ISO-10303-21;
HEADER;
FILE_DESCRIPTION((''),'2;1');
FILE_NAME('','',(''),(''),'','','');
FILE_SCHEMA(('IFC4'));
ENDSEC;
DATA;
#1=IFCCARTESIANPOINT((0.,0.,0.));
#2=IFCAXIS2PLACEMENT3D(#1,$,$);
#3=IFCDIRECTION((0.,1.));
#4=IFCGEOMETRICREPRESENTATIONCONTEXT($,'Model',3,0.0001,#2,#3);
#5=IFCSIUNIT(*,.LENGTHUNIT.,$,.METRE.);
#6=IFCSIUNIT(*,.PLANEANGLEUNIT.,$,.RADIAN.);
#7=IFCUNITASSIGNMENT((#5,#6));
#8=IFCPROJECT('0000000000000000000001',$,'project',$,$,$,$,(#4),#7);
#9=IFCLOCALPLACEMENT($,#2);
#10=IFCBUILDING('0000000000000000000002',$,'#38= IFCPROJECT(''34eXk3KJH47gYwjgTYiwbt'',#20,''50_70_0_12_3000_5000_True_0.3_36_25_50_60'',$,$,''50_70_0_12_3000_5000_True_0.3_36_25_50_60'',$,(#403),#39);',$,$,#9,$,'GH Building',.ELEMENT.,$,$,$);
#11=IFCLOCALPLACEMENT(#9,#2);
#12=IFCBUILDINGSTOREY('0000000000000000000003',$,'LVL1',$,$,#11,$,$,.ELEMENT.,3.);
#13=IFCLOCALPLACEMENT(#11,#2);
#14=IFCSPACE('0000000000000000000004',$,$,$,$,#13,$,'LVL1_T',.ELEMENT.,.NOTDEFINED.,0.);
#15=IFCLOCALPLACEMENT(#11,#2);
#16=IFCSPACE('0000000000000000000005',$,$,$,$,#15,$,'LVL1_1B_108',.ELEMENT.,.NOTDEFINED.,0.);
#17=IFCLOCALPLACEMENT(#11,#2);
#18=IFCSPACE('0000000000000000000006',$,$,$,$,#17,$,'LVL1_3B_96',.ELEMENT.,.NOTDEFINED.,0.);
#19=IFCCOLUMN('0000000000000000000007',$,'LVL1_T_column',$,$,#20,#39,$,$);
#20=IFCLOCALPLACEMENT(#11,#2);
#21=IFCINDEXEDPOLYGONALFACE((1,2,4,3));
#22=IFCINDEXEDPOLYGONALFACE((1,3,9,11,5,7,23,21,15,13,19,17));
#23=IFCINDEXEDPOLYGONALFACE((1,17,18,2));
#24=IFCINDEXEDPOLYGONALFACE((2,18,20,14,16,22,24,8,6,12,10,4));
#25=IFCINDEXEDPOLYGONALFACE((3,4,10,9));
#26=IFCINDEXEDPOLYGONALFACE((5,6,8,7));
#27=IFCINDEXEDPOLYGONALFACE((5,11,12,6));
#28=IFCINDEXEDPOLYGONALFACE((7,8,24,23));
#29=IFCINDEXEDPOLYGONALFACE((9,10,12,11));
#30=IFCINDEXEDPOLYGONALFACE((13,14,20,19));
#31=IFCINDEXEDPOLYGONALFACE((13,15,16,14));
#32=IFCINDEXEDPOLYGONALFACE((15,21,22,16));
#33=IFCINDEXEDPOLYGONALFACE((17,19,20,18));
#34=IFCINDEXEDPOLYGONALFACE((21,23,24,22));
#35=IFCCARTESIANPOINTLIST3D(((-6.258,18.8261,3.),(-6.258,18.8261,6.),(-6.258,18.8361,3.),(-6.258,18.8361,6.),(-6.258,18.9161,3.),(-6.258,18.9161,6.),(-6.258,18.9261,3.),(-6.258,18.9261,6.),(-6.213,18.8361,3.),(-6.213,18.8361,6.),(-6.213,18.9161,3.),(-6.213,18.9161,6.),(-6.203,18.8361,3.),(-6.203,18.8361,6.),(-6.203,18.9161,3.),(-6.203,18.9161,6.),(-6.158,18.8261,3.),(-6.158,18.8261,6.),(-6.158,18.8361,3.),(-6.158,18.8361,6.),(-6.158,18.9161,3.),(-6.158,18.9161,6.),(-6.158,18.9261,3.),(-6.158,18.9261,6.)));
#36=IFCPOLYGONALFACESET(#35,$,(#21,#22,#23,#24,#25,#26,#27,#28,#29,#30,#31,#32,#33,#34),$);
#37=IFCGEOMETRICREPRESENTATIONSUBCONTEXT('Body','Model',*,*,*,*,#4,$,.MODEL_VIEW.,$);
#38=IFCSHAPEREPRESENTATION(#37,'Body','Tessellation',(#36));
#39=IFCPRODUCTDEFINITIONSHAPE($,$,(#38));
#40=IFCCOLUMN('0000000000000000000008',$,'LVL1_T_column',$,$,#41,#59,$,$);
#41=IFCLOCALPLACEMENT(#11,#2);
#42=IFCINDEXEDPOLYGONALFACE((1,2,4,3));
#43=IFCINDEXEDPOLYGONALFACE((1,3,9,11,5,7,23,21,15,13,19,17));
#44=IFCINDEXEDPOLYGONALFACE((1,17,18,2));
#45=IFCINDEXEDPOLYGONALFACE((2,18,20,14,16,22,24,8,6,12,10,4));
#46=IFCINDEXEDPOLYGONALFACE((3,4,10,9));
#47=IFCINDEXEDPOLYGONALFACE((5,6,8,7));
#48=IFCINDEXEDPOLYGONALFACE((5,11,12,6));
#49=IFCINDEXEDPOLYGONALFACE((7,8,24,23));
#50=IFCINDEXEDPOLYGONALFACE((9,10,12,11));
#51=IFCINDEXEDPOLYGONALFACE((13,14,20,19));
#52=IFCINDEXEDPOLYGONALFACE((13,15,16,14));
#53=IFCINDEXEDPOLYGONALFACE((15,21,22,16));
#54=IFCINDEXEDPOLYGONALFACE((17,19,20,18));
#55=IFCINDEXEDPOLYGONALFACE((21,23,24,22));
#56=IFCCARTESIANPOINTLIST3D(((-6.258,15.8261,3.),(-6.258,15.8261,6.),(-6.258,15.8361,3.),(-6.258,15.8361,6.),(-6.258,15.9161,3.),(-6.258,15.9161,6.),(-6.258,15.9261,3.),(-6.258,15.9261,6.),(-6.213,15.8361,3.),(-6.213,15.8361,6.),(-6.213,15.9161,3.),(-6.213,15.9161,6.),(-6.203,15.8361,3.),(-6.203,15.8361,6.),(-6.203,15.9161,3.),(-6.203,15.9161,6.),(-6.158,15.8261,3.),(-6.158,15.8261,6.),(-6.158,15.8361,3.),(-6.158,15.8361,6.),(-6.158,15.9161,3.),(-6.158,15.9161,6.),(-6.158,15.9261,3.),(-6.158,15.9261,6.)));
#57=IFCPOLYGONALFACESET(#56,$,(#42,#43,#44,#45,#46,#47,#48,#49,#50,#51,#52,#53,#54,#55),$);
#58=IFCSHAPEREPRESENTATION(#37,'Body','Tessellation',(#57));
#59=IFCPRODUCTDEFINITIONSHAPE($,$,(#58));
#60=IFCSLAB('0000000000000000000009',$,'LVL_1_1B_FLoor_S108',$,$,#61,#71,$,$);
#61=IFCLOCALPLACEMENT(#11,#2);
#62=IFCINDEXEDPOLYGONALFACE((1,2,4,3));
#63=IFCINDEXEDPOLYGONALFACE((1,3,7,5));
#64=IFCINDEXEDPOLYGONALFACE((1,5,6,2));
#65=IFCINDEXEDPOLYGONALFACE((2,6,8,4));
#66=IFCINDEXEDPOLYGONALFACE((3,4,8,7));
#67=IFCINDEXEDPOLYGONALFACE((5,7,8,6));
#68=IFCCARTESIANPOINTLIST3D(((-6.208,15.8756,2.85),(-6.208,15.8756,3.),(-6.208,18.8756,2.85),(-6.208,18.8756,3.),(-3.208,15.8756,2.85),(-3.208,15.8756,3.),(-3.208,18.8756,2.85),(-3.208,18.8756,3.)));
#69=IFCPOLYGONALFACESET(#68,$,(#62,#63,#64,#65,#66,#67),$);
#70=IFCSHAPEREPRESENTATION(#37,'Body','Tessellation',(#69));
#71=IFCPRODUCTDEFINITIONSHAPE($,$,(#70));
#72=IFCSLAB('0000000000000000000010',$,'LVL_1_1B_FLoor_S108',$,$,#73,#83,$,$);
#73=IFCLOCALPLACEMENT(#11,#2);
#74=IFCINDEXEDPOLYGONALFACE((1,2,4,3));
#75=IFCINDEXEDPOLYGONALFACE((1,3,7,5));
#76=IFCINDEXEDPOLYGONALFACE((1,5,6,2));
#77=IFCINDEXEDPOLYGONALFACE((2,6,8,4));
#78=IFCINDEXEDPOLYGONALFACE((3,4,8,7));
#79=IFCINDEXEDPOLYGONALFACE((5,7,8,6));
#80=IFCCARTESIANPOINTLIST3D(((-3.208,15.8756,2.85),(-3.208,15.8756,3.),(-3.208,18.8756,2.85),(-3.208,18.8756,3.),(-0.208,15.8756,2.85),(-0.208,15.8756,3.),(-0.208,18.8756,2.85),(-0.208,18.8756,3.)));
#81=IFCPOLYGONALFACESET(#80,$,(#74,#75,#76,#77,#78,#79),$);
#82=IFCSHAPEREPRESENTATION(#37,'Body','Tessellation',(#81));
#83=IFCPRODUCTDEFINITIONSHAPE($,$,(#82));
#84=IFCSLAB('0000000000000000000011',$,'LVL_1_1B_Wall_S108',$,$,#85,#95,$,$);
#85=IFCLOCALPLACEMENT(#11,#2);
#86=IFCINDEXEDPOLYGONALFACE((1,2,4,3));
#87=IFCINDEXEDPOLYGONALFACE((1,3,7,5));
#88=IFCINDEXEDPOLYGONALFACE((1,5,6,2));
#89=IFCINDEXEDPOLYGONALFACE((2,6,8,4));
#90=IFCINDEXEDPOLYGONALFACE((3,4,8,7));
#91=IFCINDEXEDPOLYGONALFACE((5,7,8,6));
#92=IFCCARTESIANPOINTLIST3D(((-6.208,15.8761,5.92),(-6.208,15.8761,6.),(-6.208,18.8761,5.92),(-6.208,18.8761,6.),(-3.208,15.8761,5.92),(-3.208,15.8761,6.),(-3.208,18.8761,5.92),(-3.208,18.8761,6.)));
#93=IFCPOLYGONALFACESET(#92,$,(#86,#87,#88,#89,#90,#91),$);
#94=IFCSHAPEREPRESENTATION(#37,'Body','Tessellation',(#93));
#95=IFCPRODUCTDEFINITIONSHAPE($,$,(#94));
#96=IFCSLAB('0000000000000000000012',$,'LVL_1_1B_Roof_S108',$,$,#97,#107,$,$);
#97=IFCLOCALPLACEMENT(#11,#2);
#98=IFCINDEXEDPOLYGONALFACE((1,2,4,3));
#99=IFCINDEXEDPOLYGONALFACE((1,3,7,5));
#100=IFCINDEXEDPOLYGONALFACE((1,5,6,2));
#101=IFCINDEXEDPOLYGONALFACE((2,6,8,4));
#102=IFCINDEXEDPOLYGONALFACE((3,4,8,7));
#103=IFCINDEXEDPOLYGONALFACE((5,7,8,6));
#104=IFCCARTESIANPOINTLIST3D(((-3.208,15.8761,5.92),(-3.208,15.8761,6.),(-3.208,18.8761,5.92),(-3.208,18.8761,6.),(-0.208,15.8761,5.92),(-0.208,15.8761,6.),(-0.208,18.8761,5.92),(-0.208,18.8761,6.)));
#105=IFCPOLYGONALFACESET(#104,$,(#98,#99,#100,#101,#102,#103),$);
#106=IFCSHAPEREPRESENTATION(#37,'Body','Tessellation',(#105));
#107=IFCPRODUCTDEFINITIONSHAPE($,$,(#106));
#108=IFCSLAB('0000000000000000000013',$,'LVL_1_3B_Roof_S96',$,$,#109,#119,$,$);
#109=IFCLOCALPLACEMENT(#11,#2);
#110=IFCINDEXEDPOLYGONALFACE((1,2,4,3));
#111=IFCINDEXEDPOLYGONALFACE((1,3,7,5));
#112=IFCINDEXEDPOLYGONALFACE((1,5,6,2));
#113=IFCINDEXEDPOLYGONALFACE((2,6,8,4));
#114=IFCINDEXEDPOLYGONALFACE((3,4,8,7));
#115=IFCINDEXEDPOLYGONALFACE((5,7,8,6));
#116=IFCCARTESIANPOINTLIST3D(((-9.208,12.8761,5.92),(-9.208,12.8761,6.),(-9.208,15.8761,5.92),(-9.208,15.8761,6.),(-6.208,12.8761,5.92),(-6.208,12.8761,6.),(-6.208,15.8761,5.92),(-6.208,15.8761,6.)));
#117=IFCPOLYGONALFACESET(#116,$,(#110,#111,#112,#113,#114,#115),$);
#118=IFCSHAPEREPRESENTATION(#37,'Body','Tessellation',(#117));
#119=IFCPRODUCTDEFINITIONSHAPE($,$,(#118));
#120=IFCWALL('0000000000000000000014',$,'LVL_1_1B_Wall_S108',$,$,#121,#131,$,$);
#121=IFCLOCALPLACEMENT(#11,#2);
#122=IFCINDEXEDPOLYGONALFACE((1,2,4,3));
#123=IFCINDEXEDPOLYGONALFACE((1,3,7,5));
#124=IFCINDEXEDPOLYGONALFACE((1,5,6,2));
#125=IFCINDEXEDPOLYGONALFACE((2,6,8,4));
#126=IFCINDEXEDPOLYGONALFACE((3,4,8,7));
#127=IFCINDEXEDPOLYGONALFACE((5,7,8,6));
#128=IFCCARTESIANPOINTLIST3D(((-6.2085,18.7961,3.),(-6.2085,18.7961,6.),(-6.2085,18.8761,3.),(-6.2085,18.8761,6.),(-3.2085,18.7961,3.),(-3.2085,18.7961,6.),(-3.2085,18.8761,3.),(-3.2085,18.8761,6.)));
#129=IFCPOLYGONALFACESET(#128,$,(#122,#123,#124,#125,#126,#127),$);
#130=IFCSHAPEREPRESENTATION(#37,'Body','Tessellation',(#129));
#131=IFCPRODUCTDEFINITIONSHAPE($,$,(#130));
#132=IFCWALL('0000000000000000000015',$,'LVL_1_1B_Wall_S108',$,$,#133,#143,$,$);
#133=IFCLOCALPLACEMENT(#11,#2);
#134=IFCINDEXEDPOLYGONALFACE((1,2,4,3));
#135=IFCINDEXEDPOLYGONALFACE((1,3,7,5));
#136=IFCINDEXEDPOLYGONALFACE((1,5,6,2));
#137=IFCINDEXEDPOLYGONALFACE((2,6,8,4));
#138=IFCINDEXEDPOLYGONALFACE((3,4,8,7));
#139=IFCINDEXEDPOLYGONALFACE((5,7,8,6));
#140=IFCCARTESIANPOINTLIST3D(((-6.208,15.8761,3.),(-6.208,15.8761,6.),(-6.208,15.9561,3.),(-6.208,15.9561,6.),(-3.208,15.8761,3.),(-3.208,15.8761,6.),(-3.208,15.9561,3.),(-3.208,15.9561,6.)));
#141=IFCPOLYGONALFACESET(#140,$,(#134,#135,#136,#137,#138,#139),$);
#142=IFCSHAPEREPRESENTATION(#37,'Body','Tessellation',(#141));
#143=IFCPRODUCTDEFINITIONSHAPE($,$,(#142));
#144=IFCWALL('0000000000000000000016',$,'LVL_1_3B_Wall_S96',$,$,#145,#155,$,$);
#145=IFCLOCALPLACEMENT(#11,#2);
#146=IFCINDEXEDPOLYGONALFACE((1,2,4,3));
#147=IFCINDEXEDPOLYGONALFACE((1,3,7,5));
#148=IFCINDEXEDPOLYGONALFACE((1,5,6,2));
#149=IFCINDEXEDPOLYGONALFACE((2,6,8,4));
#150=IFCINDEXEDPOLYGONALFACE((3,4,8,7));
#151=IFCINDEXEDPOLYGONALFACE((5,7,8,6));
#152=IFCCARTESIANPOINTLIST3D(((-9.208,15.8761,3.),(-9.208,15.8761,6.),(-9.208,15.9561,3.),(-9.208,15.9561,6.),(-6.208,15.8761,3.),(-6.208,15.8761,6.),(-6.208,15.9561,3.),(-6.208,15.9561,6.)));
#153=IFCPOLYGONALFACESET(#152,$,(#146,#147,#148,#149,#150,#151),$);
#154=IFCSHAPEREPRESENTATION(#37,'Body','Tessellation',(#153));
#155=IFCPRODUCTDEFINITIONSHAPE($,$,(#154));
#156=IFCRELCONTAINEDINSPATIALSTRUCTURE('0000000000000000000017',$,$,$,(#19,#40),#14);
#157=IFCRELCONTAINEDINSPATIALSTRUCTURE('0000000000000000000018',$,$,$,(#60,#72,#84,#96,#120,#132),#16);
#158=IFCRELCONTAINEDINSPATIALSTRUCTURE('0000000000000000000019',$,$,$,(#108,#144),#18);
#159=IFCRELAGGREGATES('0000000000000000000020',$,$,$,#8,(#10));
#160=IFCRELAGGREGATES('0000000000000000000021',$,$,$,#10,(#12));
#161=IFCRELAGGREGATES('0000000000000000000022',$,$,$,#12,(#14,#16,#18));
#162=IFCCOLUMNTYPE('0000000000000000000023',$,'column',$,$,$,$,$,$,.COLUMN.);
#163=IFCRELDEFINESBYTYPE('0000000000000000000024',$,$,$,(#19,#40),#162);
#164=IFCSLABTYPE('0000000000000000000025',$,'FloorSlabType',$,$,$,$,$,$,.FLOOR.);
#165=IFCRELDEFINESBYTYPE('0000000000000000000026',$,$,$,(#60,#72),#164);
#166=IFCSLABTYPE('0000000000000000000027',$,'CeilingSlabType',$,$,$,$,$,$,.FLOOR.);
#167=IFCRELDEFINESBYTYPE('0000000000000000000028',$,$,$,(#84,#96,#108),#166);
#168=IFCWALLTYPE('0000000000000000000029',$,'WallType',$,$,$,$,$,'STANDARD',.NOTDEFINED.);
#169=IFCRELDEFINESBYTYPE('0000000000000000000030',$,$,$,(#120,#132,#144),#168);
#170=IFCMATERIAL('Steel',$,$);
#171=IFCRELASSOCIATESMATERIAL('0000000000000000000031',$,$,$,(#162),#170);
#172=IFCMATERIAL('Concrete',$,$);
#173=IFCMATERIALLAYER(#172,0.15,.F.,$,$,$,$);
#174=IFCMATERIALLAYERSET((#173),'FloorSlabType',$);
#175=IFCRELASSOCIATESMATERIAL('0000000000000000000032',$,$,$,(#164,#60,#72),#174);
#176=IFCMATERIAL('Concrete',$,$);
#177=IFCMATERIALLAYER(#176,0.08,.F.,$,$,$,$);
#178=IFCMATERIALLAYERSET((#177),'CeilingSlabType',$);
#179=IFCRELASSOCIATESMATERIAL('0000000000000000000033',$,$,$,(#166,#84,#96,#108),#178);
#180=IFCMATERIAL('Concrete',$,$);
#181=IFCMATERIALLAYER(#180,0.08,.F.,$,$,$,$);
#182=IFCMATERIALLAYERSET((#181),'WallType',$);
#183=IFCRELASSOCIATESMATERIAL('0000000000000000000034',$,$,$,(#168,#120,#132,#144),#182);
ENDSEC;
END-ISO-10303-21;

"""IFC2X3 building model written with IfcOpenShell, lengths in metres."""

from ifc_helpers import new_model, si_unit, direction, frame, frame_2d, origin, origin_2d, place, context, subcontext, project, spatial, rectangle, i_section, extrude, material, layer, layer_set, layer_usage, type_object, element, save


model = new_model("IFC2X3")

# Units and contexts
model_context = context("Model", 3, precision=0.0001, world=origin(), true_north=direction((0.0, 1.0)))
body_context = subcontext(model_context, "Body", "Model", "MODEL_VIEW")
ifc_project = project(units=[si_unit("LENGTHUNIT", "METRE"), si_unit("PLANEANGLEUNIT", "RADIAN")], contexts=[model_context])

# Building, storey, space
building_placement = place(None, origin())
building = spatial("IfcBuilding", under=ifc_project, at=building_placement, Name="#38= IFCPROJECT('34eXk3KJH47gYwjgTYiwbt',#20,'50_70_0_12_3000_5000_True_0.3_36_25_50_60',$,$,'50_70_0_12_3000_5000_True_0.3_36_25_50_60',$,(#403),#39);", LongName="GH Building", CompositionType="ELEMENT")
storey_placement = place(building_placement, origin())
storey = spatial("IfcBuildingStorey", under=building, at=storey_placement, Name="LVL1", CompositionType="ELEMENT", Elevation=3.0)
space_1_placement = place(storey_placement, origin())
space_1 = spatial("IfcSpace", under=storey, at=space_1_placement, LongName="LVL1_T", CompositionType="ELEMENT", InteriorOrExteriorSpace="NOTDEFINED", ElevationWithFlooring=0.0)

# Columns
ifc_material_1 = material(Name="Steel")
column_type = type_object("IfcColumnType", Name="column", PredefinedType="COLUMN", material=ifc_material_1)
for number, where, name in (
    (1, (-6.208, 18.8761, 3.0), "LVL1_T_column"),
    (2, (-6.208, 15.8761, 3.0), "LVL1_T_column"),
):
    element("IfcColumn", number, at=place(space_1_placement, frame(where)), inside=space_1, type_object=column_type, Name=name, context=body_context, shape_type="SweptSolid", body=[
        extrude(i_section(OverallWidth=0.1, OverallDepth=0.1, WebThickness=0.01, FlangeThickness=0.01, at=origin_2d()), origin(), (0.0, 0.0, 1.0), 3.0),
    ])

# Shared definitions
space_2_placement = place(storey_placement, origin())
space_2 = spatial("IfcSpace", under=storey, at=space_2_placement, LongName="LVL1_1B_108", CompositionType="ELEMENT", InteriorOrExteriorSpace="NOTDEFINED", ElevationWithFlooring=0.0)

# Slabs
ifc_material_2 = material(Name="Concrete")
ifc_layer_1 = layer(ifc_material_2, 0.15, ventilated=False)
ifc_layer_set_1 = layer_set([ifc_layer_1], Name="FloorSlabType")
ifc_layer_usage_1 = layer_usage(ifc_layer_set_1, "AXIS3", "NEGATIVE", -0.15)
slab_type_1 = type_object("IfcSlabType", Name="FloorSlabType", PredefinedType="FLOOR", material=ifc_layer_set_1)
slab_1_placement = place(space_2_placement, frame((-6.208, 15.8756, 2.85)))
element("IfcSlab", 3, at=slab_1_placement, inside=space_2, type_object=slab_type_1, material=ifc_layer_usage_1, Name="LVL_1_1B_FLoor_S108", context=body_context, shape_type="SweptSolid", body=[
    extrude(rectangle(XDim=3.0, YDim=3.0, at=frame_2d((1.5, 1.5))), origin(), (0.0, 0.0, 1.0), 0.15),
])
ifc_layer_usage_2 = layer_usage(ifc_layer_set_1, "AXIS3", "NEGATIVE", -0.15)
slab_2_placement = place(space_2_placement, frame((-3.208, 15.8756, 2.85)))
element("IfcSlab", 4, at=slab_2_placement, inside=space_2, type_object=slab_type_1, material=ifc_layer_usage_2, Name="LVL_1_1B_FLoor_S108", context=body_context, shape_type="SweptSolid", body=[
    extrude(rectangle(XDim=3.0, YDim=3.0, at=frame_2d((1.5, 1.5))), origin(), (0.0, 0.0, 1.0), 0.15),
])
ifc_material_3 = material(Name="Concrete")
ifc_layer_2 = layer(ifc_material_3, 0.08, ventilated=False)
ifc_layer_set_2 = layer_set([ifc_layer_2], Name="CeilingSlabType")
ifc_layer_usage_3 = layer_usage(ifc_layer_set_2, "AXIS3", "NEGATIVE", -0.08)
slab_type_2 = type_object("IfcSlabType", Name="CeilingSlabType", PredefinedType="FLOOR", material=ifc_layer_set_2)
slab_3_placement = place(space_2_placement, frame((-6.208, 15.8761, 5.92)))
element("IfcSlab", 5, at=slab_3_placement, inside=space_2, type_object=slab_type_2, material=ifc_layer_usage_3, Name="LVL_1_1B_Wall_S108", context=body_context, shape_type="SweptSolid", body=[
    extrude(rectangle(XDim=3.0, YDim=3.0, at=frame_2d((1.5, 1.5))), origin(), (0.0, 0.0, 1.0), 0.08),
])
ifc_layer_usage_4 = layer_usage(ifc_layer_set_2, "AXIS3", "NEGATIVE", -0.08)
slab_4_placement = place(space_2_placement, frame((-3.208, 15.8761, 5.92)))
element("IfcSlab", 6, at=slab_4_placement, inside=space_2, type_object=slab_type_2, material=ifc_layer_usage_4, Name="LVL_1_1B_Roof_S108", context=body_context, shape_type="SweptSolid", body=[
    extrude(rectangle(XDim=3.0, YDim=3.0, at=frame_2d((1.5, 1.5))), origin(), (0.0, 0.0, 1.0), 0.08),
])

# Shared definitions
space_3_placement = place(storey_placement, origin())
space_3 = spatial("IfcSpace", under=storey, at=space_3_placement, LongName="LVL1_3B_96", CompositionType="ELEMENT", InteriorOrExteriorSpace="NOTDEFINED", ElevationWithFlooring=0.0)

# Slab
ifc_layer_usage_5 = layer_usage(ifc_layer_set_2, "AXIS3", "NEGATIVE", -0.08)
slab_5_placement = place(space_3_placement, frame((-6.208, 12.8761, 5.92), z_axis=(0.0, 0.0, 1.0), x_axis=(-1.0, 0.0, 0.0)))
element("IfcSlab", 7, at=slab_5_placement, inside=space_3, type_object=slab_type_2, material=ifc_layer_usage_5, Name="LVL_1_3B_Roof_S96", context=body_context, shape_type="SweptSolid", body=[
    extrude(rectangle(XDim=3.0, YDim=3.0, at=frame_2d((1.5, -1.5))), origin(), (0.0, 0.0, 1.0), 0.08),
])

# Shared definitions
ifc_material_4 = material(Name="Concrete")
ifc_layer_3 = layer(ifc_material_4, 0.08, ventilated=False)
ifc_layer_set_3 = layer_set([ifc_layer_3], Name="WallType")
wall_type = type_object("IfcWallType", Name="WallType", ElementType="STANDARD", PredefinedType="NOTDEFINED", material=ifc_layer_set_3)

# Walls
ifc_layer_usage_6 = layer_usage(ifc_layer_set_3, "AXIS2", "NEGATIVE", 0.0)
wall_1_placement = place(space_2_placement, frame((-6.2085, 18.8761, 3.0)))
element("IfcWall", 8, at=wall_1_placement, inside=space_2, type_object=wall_type, material=ifc_layer_usage_6, Name="LVL_1_1B_Wall_S108", context=body_context, shape_type="SweptSolid", body=[
    extrude(rectangle(XDim=3.0, YDim=0.08, at=frame_2d((1.5, -0.04))), origin(), (0.0, 0.0, 1.0), 3.0),
])
ifc_layer_usage_7 = layer_usage(ifc_layer_set_3, "AXIS2", "NEGATIVE", 0.0)
wall_2_placement = place(space_2_placement, frame((-3.208, 15.8761, 3.0), z_axis=(0.0, 0.0, 1.0), x_axis=(-1.0, 0.0, 0.0)))
element("IfcWall", 9, at=wall_2_placement, inside=space_2, type_object=wall_type, material=ifc_layer_usage_7, Name="LVL_1_1B_Wall_S108", context=body_context, shape_type="SweptSolid", body=[
    extrude(rectangle(XDim=3.0, YDim=0.08, at=frame_2d((1.5, -0.04))), origin(), (0.0, 0.0, 1.0), 3.0),
])

# Wall
ifc_layer_usage_8 = layer_usage(ifc_layer_set_3, "AXIS2", "NEGATIVE", 0.0)
wall_3_placement = place(space_3_placement, frame((-6.208, 15.8761, 3.0), z_axis=(0.0, 0.0, 1.0), x_axis=(-1.0, 0.0, 0.0)))
element("IfcWall", 10, at=wall_3_placement, inside=space_3, type_object=wall_type, material=ifc_layer_usage_8, Name="LVL_1_3B_Wall_S96", context=body_context, shape_type="SweptSolid", body=[
    extrude(rectangle(XDim=3.0, YDim=0.08, at=frame_2d((1.5, -0.04))), origin(), (0.0, 0.0, 1.0), 3.0),
])

save(model, "model.ifc")
